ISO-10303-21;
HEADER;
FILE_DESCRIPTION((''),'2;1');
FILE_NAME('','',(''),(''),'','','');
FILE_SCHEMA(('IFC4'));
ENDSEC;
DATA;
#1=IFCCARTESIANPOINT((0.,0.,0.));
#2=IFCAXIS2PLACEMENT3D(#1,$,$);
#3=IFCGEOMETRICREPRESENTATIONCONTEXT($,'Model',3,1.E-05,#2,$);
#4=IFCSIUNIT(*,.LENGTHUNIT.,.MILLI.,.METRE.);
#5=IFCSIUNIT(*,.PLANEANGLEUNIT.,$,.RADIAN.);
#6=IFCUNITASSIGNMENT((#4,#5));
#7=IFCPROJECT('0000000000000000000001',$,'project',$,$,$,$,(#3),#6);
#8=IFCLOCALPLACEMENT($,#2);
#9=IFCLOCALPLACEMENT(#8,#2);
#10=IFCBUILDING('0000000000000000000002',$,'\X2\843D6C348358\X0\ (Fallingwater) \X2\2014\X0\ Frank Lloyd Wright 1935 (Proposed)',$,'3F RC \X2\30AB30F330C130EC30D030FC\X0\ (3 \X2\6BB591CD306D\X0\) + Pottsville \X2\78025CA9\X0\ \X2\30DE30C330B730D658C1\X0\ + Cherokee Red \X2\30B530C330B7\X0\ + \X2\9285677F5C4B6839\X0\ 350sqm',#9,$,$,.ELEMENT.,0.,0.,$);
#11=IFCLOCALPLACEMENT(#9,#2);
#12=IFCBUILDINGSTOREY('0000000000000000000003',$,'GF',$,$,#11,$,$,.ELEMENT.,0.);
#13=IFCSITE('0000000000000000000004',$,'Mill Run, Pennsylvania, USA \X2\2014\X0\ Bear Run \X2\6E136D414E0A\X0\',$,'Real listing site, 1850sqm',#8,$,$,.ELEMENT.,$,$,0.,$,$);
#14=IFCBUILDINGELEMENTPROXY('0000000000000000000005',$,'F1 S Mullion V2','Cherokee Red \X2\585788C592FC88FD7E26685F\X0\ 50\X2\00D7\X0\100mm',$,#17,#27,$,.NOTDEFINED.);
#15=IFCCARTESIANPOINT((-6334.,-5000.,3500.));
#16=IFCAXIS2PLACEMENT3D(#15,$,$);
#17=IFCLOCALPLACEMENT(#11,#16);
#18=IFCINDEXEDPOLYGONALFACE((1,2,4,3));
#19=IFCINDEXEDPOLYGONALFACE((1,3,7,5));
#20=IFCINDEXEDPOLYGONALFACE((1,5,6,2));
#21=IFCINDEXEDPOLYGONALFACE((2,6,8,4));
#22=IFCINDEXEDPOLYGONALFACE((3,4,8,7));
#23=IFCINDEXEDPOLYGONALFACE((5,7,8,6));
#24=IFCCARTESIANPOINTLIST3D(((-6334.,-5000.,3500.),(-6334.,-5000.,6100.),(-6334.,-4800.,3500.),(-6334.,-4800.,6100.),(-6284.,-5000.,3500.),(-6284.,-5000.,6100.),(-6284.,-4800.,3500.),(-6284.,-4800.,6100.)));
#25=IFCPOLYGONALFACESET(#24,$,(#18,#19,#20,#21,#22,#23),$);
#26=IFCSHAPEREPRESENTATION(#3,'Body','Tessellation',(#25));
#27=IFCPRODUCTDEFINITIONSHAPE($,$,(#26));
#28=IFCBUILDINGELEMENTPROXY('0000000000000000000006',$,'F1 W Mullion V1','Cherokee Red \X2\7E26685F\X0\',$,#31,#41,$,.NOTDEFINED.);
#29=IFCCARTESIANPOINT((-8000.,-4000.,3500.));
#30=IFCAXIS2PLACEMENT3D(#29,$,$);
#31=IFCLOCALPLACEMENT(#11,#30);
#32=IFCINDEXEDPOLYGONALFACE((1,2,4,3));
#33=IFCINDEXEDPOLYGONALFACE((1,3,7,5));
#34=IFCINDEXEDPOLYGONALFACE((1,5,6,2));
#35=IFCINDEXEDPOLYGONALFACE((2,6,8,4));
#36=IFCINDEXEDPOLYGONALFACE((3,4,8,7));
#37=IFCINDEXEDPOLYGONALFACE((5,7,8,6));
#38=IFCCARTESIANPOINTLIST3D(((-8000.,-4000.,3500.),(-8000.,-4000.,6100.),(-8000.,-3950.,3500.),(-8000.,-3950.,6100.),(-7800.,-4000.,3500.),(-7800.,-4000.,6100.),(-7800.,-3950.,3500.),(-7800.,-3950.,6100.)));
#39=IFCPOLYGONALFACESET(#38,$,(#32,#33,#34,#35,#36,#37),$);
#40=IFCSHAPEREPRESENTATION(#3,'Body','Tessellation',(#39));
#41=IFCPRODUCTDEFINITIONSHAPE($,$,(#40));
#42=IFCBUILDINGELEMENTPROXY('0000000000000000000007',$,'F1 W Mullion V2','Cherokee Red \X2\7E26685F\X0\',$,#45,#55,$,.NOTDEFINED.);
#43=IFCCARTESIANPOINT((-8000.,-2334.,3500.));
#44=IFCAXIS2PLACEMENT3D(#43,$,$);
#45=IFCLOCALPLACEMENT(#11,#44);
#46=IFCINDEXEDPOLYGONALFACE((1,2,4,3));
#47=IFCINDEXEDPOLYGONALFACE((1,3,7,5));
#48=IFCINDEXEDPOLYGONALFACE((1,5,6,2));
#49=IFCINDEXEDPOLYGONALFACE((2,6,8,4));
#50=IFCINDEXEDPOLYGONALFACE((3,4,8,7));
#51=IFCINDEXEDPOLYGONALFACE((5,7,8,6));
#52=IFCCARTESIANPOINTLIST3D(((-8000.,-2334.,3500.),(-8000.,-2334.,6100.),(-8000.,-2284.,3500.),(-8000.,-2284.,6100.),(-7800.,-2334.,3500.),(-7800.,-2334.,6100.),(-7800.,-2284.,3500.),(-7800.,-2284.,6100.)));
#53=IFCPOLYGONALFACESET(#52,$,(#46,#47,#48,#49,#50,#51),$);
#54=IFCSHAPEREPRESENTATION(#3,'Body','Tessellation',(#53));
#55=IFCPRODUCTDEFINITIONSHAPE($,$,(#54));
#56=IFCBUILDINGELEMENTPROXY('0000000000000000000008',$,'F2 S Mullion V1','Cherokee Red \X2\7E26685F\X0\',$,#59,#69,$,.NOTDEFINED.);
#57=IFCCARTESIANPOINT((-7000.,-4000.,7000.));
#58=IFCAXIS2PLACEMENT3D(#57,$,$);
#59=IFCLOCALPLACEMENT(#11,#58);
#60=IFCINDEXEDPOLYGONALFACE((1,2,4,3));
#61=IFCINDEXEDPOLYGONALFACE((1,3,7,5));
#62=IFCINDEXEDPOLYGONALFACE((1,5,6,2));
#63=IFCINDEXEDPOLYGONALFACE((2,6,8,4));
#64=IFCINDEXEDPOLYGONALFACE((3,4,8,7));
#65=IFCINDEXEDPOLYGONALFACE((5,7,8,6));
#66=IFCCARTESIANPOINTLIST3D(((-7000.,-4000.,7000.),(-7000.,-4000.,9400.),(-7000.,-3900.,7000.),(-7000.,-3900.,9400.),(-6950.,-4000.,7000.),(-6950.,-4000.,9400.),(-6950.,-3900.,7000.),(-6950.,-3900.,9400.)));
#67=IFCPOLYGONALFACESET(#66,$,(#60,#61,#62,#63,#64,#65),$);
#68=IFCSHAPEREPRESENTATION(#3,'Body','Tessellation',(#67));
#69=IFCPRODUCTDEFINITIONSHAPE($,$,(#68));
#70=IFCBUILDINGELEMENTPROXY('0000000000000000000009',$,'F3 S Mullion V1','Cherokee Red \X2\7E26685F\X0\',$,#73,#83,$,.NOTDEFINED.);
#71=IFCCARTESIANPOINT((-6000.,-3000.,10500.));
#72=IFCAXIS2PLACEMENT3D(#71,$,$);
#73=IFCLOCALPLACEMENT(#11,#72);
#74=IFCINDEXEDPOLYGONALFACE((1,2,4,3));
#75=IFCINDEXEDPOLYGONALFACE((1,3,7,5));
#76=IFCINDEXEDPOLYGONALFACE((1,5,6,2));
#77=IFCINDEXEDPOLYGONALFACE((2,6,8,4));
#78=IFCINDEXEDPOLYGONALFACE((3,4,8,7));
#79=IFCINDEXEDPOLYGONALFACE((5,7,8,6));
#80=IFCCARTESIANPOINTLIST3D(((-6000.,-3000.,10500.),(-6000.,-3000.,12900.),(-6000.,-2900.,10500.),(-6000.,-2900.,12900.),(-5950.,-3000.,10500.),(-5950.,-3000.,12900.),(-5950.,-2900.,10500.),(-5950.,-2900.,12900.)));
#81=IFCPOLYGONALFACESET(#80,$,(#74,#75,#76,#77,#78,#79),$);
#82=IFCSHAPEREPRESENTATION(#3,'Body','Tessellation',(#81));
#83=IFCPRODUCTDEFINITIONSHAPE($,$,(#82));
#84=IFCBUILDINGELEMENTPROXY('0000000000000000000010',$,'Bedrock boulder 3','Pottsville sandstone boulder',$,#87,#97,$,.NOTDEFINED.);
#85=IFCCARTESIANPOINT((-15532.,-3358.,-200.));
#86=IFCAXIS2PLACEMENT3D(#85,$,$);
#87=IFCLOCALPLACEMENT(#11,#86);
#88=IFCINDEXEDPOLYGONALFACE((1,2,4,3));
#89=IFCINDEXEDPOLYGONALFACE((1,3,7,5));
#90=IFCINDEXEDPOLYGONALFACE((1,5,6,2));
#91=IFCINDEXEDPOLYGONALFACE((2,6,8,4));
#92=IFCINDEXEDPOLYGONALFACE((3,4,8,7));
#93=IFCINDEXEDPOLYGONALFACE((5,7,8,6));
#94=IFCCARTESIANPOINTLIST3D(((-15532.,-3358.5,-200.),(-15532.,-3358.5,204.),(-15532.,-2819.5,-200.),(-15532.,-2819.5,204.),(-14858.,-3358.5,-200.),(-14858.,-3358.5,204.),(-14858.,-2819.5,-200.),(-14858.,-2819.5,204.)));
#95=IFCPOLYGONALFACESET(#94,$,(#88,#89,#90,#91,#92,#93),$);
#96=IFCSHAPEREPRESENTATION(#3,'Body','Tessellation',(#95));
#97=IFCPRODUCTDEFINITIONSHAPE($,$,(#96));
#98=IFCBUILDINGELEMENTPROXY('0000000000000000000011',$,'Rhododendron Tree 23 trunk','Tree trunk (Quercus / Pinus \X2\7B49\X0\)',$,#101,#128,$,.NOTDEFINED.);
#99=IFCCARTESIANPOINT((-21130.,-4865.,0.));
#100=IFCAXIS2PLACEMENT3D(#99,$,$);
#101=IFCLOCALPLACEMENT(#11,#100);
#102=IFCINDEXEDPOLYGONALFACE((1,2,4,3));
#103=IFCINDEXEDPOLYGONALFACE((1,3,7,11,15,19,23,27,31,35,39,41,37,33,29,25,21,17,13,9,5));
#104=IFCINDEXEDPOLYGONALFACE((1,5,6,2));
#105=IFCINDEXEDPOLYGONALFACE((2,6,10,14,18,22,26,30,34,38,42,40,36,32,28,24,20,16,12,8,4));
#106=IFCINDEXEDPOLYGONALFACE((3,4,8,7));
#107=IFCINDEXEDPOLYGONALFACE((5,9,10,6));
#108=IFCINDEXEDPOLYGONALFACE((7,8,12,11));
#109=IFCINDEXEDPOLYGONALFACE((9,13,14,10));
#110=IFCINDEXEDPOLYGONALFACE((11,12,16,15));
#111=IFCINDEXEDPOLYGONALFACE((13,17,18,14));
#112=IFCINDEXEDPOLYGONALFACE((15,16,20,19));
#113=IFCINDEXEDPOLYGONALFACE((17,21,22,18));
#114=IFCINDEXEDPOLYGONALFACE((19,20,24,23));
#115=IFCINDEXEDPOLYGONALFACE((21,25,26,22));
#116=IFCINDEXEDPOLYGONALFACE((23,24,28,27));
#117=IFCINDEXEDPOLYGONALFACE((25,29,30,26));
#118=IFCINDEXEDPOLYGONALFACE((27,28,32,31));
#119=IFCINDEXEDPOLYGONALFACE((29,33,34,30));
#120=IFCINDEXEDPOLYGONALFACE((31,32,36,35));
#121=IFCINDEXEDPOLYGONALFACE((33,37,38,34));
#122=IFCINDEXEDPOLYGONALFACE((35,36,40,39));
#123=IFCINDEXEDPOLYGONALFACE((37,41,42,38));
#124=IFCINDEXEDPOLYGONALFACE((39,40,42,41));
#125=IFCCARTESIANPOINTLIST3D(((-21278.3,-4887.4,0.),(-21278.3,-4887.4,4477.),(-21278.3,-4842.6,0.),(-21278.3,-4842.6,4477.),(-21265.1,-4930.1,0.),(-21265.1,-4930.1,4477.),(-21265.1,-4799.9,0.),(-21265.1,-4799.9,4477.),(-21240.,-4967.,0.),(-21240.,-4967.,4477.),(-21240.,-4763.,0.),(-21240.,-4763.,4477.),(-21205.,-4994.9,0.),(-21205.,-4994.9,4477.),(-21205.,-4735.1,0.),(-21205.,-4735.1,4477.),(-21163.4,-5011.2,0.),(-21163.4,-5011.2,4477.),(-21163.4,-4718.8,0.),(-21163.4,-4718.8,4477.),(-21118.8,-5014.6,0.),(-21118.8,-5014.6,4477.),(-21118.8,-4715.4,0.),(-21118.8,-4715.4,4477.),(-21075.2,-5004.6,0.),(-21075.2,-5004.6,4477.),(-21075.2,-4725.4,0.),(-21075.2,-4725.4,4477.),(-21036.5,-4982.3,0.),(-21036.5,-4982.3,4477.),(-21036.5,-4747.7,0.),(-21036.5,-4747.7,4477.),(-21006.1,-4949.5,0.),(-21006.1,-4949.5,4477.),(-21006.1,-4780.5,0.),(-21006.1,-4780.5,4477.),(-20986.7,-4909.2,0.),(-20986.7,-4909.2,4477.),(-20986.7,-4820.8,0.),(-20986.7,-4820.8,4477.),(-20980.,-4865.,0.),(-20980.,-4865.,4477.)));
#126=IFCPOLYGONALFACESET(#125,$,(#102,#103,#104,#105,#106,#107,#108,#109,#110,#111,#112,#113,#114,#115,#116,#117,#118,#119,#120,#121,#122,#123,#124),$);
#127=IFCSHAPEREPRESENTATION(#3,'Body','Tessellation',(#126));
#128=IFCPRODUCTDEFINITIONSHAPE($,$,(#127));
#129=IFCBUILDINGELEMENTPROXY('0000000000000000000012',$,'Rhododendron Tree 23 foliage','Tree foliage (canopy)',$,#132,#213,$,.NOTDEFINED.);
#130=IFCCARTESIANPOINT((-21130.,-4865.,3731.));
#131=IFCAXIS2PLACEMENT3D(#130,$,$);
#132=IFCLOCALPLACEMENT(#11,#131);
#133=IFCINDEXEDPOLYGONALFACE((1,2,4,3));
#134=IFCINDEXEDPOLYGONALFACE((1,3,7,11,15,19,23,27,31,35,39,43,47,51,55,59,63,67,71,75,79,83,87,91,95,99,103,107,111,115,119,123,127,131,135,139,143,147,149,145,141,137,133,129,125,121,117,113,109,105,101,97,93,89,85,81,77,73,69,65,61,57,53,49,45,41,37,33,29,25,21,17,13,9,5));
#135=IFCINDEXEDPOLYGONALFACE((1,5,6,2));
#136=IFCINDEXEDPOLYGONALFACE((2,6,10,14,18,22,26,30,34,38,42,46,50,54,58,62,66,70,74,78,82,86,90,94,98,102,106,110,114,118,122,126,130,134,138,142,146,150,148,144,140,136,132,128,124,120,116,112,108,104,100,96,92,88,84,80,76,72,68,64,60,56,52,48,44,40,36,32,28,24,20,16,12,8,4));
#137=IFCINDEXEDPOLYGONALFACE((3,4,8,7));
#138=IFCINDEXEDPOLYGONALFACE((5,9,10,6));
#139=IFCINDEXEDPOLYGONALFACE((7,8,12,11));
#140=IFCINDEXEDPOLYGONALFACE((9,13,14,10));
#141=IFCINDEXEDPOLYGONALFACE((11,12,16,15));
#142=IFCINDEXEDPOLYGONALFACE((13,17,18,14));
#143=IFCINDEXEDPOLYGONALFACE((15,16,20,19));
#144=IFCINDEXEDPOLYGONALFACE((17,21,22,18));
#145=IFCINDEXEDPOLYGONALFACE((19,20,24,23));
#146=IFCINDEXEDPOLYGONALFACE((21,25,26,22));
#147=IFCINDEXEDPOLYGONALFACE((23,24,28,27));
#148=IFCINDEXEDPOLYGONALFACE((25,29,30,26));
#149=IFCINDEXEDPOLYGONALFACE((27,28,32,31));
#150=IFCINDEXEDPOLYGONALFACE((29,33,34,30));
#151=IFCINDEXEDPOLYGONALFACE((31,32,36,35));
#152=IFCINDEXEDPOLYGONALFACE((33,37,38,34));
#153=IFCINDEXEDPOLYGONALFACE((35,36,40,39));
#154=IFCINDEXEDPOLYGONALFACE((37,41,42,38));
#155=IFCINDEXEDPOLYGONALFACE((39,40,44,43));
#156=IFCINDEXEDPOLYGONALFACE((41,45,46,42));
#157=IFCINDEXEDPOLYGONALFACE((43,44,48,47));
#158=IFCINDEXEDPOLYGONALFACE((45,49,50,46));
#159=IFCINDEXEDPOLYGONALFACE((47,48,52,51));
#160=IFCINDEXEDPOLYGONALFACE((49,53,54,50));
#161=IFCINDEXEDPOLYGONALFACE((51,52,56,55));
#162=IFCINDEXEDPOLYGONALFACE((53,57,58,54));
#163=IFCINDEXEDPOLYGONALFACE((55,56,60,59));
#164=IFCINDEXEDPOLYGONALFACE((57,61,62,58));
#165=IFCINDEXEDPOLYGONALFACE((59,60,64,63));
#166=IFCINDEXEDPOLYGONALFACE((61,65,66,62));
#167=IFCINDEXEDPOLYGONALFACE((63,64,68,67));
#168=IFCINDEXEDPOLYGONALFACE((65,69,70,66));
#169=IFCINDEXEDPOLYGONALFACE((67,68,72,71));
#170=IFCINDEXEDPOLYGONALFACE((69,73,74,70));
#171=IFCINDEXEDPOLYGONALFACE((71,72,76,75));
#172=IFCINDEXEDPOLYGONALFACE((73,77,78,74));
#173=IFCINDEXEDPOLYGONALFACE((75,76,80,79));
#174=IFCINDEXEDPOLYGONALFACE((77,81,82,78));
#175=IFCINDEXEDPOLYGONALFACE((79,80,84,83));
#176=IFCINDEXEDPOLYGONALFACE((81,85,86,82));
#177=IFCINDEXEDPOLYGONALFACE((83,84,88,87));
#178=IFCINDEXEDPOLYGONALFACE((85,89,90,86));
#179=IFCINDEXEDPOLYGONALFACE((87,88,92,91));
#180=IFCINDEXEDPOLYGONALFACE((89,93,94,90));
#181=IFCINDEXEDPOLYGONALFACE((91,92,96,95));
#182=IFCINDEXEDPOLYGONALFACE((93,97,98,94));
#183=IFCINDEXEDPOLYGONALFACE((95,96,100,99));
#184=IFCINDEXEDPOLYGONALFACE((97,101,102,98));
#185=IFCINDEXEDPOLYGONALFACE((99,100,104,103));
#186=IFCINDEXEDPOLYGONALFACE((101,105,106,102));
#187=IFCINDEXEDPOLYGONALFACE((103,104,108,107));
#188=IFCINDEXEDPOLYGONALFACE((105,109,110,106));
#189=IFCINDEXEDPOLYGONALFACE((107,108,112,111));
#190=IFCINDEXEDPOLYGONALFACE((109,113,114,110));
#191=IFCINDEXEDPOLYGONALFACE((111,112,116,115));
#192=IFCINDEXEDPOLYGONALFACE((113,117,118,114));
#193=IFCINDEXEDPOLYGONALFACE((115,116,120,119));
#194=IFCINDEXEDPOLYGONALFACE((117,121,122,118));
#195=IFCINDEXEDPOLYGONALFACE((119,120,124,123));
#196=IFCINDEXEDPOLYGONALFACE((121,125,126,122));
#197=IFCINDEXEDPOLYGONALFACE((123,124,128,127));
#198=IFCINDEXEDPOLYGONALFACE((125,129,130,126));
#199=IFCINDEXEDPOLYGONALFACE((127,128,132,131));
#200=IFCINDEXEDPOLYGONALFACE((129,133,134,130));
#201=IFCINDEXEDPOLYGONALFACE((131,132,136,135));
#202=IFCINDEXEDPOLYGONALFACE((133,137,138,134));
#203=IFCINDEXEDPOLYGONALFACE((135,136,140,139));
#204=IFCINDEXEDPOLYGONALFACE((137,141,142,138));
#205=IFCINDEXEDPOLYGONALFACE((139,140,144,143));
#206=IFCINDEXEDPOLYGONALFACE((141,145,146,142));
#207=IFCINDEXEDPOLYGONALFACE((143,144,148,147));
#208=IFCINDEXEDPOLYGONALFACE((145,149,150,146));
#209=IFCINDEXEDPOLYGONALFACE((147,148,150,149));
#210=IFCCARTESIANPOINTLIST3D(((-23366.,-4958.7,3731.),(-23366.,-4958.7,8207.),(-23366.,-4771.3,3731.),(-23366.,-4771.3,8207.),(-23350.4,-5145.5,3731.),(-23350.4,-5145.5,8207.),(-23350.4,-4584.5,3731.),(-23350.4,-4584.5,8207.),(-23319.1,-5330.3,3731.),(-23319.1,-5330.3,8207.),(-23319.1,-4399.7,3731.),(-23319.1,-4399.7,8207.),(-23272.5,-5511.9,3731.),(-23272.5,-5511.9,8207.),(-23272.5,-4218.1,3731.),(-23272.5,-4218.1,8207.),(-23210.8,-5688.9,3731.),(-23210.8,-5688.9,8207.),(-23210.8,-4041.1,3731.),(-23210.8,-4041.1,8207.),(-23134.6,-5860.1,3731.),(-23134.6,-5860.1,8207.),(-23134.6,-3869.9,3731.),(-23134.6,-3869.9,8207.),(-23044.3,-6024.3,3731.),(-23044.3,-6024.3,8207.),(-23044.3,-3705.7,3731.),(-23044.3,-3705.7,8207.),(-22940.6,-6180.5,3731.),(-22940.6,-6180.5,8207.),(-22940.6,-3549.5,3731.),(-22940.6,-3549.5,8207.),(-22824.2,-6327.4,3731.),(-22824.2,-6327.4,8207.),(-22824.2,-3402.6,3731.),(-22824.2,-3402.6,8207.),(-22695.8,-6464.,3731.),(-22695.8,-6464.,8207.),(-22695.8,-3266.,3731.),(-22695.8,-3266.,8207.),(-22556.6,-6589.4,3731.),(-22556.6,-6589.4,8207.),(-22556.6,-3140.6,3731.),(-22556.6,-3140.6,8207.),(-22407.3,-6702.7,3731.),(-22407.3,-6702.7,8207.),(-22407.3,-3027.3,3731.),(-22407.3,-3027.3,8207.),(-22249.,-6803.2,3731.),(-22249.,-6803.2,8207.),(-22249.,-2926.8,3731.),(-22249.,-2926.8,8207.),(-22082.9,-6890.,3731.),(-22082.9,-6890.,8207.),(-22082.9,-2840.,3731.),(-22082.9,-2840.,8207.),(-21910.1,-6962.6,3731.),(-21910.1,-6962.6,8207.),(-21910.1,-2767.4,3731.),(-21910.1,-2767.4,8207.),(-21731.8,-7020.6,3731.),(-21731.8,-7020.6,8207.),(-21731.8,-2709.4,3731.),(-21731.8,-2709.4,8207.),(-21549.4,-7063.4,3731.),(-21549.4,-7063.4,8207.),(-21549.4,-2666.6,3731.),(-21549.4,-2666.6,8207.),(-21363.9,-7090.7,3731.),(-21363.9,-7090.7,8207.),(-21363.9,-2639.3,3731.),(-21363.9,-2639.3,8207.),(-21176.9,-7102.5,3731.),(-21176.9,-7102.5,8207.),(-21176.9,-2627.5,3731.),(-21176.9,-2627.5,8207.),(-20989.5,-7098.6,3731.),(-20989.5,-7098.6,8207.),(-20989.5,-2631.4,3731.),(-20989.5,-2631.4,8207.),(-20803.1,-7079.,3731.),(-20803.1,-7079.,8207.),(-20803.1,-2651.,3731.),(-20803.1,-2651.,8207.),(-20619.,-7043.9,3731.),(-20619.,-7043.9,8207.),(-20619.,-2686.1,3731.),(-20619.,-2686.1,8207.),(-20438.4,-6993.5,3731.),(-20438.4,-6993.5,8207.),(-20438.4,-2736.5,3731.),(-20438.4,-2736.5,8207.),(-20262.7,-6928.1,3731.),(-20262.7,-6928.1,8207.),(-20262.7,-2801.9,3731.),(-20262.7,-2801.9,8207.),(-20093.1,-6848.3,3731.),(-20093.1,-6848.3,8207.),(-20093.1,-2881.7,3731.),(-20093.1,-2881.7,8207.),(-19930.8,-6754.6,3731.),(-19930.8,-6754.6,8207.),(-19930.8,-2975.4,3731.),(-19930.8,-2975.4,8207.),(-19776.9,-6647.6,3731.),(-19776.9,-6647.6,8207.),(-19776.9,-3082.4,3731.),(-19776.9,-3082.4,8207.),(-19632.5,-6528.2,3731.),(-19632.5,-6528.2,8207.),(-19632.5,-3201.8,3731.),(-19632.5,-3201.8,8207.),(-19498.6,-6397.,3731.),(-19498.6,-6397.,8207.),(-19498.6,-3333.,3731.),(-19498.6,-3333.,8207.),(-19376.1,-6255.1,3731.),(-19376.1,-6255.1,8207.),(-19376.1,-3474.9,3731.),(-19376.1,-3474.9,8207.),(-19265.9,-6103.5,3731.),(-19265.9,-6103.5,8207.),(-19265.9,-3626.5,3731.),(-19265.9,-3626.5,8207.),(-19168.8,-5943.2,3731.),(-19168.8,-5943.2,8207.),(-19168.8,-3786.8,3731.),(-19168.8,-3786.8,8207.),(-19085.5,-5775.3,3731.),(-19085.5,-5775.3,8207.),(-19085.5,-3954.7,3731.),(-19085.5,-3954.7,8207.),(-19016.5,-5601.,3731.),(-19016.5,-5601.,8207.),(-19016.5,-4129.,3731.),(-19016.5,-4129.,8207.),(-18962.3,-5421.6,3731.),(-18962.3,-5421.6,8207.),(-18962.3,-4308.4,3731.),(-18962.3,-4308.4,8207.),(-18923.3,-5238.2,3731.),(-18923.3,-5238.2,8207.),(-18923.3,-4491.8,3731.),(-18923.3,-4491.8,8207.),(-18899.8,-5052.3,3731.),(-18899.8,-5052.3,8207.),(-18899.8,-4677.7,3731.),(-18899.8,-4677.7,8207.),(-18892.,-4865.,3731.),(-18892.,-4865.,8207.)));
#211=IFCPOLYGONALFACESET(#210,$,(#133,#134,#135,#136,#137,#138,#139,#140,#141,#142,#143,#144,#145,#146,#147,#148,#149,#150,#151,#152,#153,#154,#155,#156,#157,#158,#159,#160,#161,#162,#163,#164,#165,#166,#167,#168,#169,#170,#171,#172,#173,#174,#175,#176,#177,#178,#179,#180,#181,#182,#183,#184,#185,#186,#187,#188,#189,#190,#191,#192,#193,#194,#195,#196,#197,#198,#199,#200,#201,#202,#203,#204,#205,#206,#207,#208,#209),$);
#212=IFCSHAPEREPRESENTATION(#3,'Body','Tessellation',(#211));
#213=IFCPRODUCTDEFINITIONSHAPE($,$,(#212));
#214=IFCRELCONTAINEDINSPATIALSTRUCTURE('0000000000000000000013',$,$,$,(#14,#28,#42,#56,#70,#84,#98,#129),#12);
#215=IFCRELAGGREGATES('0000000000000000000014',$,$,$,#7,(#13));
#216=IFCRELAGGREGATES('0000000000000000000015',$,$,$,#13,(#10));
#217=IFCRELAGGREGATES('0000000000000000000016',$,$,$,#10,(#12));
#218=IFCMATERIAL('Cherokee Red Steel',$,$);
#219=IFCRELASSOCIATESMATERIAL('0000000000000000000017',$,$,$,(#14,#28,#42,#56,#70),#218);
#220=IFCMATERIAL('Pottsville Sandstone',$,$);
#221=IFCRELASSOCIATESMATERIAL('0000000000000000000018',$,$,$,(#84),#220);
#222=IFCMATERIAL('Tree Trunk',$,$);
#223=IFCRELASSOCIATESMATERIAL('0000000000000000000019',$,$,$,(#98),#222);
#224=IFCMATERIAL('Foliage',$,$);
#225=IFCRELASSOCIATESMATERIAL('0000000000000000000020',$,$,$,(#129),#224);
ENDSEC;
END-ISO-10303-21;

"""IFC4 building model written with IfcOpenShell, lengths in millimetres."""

from ifc_helpers import new_model, si_unit, frame, frame_2d, origin, origin_2d, place, context, project, spatial, rectangle, circle, extrude, material, element, save


model = new_model("IFC4")

# Units and contexts
model_context = context("Model", 3, precision=1e-05, world=origin())
ifc_project = project(units=[si_unit("LENGTHUNIT", "METRE", prefix="MILLI"), si_unit("PLANEANGLEUNIT", "RADIAN")], contexts=[model_context])

# Site, building, storey
site_placement = place(None, origin())
site = spatial("IfcSite", under=ifc_project, at=site_placement, Name="Mill Run, Pennsylvania, USA — Bear Run 渓流上", ObjectType="Real listing site, 1850sqm", CompositionType="ELEMENT", RefElevation=0.0)
building_placement = place(site_placement, origin())
building = spatial("IfcBuilding", under=site, at=building_placement, Name="落水荘 (Fallingwater) — Frank Lloyd Wright 1935 (Proposed)", ObjectType="3F RC カンチレバー (3 段重ね) + Pottsville 砂岩 マッシブ壁 + Cherokee Red サッシ + 銅板屋根 350sqm", CompositionType="ELEMENT", ElevationOfRefHeight=0.0, ElevationOfTerrain=0.0)
storey_placement = place(building_placement, origin())
storey = spatial("IfcBuildingStorey", under=building, at=storey_placement, Name="GF", CompositionType="ELEMENT", Elevation=0.0)

# Shared definitions
ifc_material_1 = material(Name="Cherokee Red Steel")

# Building element proxies
proxy_1_placement = place(storey_placement, frame((-6334.0, -5000.0, 3500.0)))
element("IfcBuildingElementProxy", 1, at=proxy_1_placement, inside=storey, material=ifc_material_1, Name="F1 S Mullion V2", Description="Cherokee Red 塗装鋼製縦桟 50×100mm", PredefinedType="NOTDEFINED", context=model_context, shape_type="SweptSolid", body=[
    extrude(rectangle(XDim=50.0, YDim=200.0, at=frame_2d((25.0, 100.0))), frame((-6334.0, -5000.0, 3500.0)), (0.0, 0.0, 1.0), 2600.0),
])
proxy_2_placement = place(storey_placement, frame((-8000.0, -4000.0, 3500.0)))
element("IfcBuildingElementProxy", 2, at=proxy_2_placement, inside=storey, material=ifc_material_1, Name="F1 W Mullion V1", Description="Cherokee Red 縦桟", PredefinedType="NOTDEFINED", context=model_context, shape_type="SweptSolid", body=[
    extrude(rectangle(XDim=200.0, YDim=50.0, at=frame_2d((100.0, 25.0))), frame((-8000.0, -4000.0, 3500.0)), (0.0, 0.0, 1.0), 2600.0),
])
proxy_3_placement = place(storey_placement, frame((-8000.0, -2334.0, 3500.0)))
element("IfcBuildingElementProxy", 3, at=proxy_3_placement, inside=storey, material=ifc_material_1, Name="F1 W Mullion V2", Description="Cherokee Red 縦桟", PredefinedType="NOTDEFINED", context=model_context, shape_type="SweptSolid", body=[
    extrude(rectangle(XDim=200.0, YDim=50.0, at=frame_2d((100.0, 25.0))), frame((-8000.0, -2334.0, 3500.0)), (0.0, 0.0, 1.0), 2600.0),
])
proxy_4_placement = place(storey_placement, frame((-7000.0, -4000.0, 7000.0)))
element("IfcBuildingElementProxy", 4, at=proxy_4_placement, inside=storey, material=ifc_material_1, Name="F2 S Mullion V1", Description="Cherokee Red 縦桟", PredefinedType="NOTDEFINED", context=model_context, shape_type="SweptSolid", body=[
    extrude(rectangle(XDim=50.0, YDim=100.0, at=frame_2d((25.0, 50.0))), frame((-7000.0, -4000.0, 7000.0)), (0.0, 0.0, 1.0), 2400.0),
])
proxy_5_placement = place(storey_placement, frame((-6000.0, -3000.0, 10500.0)))
element("IfcBuildingElementProxy", 5, at=proxy_5_placement, inside=storey, material=ifc_material_1, Name="F3 S Mullion V1", Description="Cherokee Red 縦桟", PredefinedType="NOTDEFINED", context=model_context, shape_type="SweptSolid", body=[
    extrude(rectangle(XDim=50.0, YDim=100.0, at=frame_2d((25.0, 50.0))), frame((-6000.0, -3000.0, 10500.0)), (0.0, 0.0, 1.0), 2400.0),
])
ifc_material_2 = material(Name="Pottsville Sandstone")
proxy_6_placement = place(storey_placement, frame((-15532.0, -3358.0, -200.0)))
element("IfcBuildingElementProxy", 6, at=proxy_6_placement, inside=storey, material=ifc_material_2, Name="Bedrock boulder 3", Description="Pottsville sandstone boulder", PredefinedType="NOTDEFINED", context=model_context, shape_type="SweptSolid", body=[
    extrude(rectangle(XDim=674.0, YDim=539.0, at=frame_2d((337.0, 269.0))), frame((-15532.0, -3358.0, -200.0)), (0.0, 0.0, 1.0), 404.0),
])
ifc_material_3 = material(Name="Tree Trunk")
proxy_7_placement = place(storey_placement, frame((-21130.0, -4865.0, 0.0)))
element("IfcBuildingElementProxy", 7, at=proxy_7_placement, inside=storey, material=ifc_material_3, Name="Rhododendron Tree 23 trunk", Description="Tree trunk (Quercus / Pinus 等)", PredefinedType="NOTDEFINED", context=model_context, shape_type="SweptSolid", body=[
    extrude(circle(Radius=150.0, at=origin_2d()), frame((-21130.0, -4865.0, 0.0)), (0.0, 0.0, 1.0), 4477.0),
])
ifc_material_4 = material(Name="Foliage")
proxy_8_placement = place(storey_placement, frame((-21130.0, -4865.0, 3731.0)))
element("IfcBuildingElementProxy", 8, at=proxy_8_placement, inside=storey, material=ifc_material_4, Name="Rhododendron Tree 23 foliage", Description="Tree foliage (canopy)", PredefinedType="NOTDEFINED", context=model_context, shape_type="SweptSolid", body=[
    extrude(circle(Radius=2238.0, at=origin_2d()), frame((-21130.0, -4865.0, 3731.0)), (0.0, 0.0, 1.0), 4476.0),
])

save(model, "model.ifc")
